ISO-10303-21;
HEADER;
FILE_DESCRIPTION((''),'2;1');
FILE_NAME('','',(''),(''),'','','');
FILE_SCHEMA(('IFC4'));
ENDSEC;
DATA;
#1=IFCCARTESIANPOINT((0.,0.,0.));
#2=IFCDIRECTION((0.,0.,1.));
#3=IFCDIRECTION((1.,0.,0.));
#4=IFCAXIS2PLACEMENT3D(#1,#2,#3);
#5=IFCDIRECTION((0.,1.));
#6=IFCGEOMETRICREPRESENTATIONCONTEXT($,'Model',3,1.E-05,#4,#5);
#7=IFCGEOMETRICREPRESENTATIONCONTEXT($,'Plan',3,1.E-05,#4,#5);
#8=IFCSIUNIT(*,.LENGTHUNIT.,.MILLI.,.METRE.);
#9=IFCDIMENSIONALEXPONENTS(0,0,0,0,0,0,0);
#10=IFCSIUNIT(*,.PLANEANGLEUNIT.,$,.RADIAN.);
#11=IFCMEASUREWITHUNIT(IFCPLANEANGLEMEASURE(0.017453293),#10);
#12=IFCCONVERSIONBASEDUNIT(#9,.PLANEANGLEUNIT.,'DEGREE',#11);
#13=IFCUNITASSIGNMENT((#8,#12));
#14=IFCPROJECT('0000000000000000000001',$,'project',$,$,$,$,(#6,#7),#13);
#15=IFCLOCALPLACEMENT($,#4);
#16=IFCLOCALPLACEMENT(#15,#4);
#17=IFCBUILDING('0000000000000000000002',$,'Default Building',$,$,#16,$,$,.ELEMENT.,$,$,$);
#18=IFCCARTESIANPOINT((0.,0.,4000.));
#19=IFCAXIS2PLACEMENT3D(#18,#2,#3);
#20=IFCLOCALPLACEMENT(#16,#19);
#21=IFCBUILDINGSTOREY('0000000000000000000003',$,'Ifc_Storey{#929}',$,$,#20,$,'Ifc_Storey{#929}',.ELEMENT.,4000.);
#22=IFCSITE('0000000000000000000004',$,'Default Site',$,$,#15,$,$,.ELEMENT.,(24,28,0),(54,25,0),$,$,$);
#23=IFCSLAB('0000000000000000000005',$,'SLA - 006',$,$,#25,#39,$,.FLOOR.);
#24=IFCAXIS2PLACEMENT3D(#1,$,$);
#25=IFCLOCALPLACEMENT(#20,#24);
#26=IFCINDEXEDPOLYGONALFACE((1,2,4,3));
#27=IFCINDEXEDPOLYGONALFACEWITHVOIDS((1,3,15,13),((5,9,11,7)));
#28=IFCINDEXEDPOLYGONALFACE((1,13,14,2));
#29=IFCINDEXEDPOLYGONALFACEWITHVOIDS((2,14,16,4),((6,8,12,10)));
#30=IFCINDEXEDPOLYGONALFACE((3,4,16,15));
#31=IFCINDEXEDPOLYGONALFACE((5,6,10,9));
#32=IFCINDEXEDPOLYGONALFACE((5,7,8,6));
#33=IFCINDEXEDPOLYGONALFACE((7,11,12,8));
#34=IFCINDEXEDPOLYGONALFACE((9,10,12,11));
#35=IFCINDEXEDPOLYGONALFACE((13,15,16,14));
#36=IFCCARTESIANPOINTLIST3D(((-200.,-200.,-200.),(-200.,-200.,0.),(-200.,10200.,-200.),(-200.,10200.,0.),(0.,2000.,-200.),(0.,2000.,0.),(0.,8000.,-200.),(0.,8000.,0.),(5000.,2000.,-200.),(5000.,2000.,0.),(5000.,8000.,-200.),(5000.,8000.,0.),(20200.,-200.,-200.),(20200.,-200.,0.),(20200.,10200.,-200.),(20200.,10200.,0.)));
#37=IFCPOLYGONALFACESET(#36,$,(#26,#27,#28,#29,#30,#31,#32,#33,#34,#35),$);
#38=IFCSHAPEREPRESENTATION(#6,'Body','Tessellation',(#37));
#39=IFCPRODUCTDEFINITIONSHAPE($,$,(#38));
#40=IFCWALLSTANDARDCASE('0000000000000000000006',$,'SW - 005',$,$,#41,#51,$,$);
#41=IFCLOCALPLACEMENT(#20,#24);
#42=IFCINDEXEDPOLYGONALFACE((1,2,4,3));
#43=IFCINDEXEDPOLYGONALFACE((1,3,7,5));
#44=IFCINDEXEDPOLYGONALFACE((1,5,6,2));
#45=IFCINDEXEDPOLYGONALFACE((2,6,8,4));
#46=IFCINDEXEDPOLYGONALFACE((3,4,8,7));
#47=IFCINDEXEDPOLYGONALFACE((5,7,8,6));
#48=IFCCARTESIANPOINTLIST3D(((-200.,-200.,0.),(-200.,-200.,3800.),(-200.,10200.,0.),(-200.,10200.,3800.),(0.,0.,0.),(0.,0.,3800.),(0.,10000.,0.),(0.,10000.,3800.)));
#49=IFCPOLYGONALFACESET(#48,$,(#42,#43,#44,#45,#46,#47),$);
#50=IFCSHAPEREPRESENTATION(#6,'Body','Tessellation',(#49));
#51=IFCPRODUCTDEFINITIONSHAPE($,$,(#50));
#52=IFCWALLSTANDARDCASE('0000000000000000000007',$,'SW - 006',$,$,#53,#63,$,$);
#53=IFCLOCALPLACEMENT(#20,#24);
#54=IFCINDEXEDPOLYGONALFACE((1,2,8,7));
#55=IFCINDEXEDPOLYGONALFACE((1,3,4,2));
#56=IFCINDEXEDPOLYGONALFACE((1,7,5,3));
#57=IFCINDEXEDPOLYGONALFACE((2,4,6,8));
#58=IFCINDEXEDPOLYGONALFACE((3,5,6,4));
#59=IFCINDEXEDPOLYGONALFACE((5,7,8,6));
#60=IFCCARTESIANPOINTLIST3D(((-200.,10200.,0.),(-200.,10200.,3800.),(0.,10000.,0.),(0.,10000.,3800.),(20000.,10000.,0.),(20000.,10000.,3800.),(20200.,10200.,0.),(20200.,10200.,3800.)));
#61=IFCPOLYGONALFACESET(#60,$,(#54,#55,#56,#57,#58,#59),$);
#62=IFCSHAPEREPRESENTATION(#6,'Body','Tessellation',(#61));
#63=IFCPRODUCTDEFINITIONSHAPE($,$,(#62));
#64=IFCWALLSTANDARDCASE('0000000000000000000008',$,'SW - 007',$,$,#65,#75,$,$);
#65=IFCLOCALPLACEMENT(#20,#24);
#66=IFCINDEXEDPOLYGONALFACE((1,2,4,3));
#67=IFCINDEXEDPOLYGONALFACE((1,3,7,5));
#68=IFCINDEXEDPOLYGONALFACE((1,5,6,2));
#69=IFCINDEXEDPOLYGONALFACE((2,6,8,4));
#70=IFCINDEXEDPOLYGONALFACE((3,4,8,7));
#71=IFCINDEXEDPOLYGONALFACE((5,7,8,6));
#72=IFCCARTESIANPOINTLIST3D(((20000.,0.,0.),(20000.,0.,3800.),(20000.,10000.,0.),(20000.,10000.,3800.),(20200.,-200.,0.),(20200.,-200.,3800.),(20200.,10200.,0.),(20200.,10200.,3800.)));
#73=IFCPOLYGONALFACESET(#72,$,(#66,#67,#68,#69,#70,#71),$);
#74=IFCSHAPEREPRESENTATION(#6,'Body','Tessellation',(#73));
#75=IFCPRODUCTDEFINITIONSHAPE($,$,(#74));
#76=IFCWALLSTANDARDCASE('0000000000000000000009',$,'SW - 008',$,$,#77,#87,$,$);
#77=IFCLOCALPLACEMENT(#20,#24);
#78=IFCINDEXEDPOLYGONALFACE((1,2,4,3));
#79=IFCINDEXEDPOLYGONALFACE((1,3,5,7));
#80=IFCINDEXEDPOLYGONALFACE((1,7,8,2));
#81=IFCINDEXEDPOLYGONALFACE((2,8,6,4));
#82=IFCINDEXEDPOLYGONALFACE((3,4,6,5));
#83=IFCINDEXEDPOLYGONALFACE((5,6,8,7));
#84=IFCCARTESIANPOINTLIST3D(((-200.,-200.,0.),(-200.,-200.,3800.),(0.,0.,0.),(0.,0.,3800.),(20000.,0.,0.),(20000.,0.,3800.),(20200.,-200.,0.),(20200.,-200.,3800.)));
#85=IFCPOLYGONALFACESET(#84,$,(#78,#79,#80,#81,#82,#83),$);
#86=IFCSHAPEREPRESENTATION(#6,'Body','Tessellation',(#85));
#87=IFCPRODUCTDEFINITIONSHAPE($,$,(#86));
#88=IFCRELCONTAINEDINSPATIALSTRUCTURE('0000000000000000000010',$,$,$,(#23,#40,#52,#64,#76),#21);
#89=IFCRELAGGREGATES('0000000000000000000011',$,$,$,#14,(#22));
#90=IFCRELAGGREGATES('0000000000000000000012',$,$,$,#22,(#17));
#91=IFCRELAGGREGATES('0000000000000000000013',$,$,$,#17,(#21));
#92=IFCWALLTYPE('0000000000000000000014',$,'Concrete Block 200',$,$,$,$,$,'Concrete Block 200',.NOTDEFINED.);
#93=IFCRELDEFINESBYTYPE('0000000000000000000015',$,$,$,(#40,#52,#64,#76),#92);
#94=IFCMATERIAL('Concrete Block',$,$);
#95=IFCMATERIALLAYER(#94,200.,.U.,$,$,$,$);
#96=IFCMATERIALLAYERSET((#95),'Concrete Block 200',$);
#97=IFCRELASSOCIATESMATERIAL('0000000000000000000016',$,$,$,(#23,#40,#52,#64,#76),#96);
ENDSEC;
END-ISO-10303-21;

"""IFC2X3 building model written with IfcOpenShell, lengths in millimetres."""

from ifc_helpers import new_model, entity, si_unit, converted_unit, direction, frame, origin_with_axes, place, context, project, spatial, polyline, outline, extrude, material, layer, layer_set, layer_usage, type_object, element, save


model = new_model("IFC2X3")

# Units and contexts
model_context = context("Model", 3, precision=1e-05, world=origin_with_axes(), true_north=direction((0.0, 1.0)))
plan_context = context("Plan", 3, precision=1e-05, world=origin_with_axes(), true_north=direction((0.0, 1.0)))
ifc_project = project(units=[si_unit("LENGTHUNIT", "METRE", prefix="MILLI"), converted_unit("PLANEANGLEUNIT", "DEGREE", entity("IfcPlaneAngleMeasure", 0.017453293), si_unit("PLANEANGLEUNIT", "RADIAN"), dimensions=[0, 0, 0, 0, 0, 0, 0])], contexts=[model_context, plan_context])

# Site, building, storey
site_placement = place(None, origin_with_axes())
site = spatial("IfcSite", under=ifc_project, at=site_placement, Name="Default Site", CompositionType="ELEMENT", RefLatitude=(24, 28, 0), RefLongitude=(54, 25, 0))
building_placement = place(site_placement, origin_with_axes())
building = spatial("IfcBuilding", under=site, at=building_placement, Name="Default Building", CompositionType="ELEMENT")
storey_placement = place(building_placement, frame((0.0, 0.0, 4000.0), z_axis=(0.0, 0.0, 1.0), x_axis=(1.0, 0.0, 0.0)))
storey = spatial("IfcBuildingStorey", under=building, at=storey_placement, Name="Ifc_Storey{#929}", LongName="Ifc_Storey{#929}", CompositionType="ELEMENT", Elevation=4000.0)

# Slab, opening
ifc_material = material(Name="Concrete Block")
ifc_layer = layer(ifc_material, 200.0, ventilated="UNKNOWN")
ifc_layer_set = layer_set([ifc_layer], Name="Concrete Block 200")
ifc_layer_usage_1 = layer_usage(ifc_layer_set, "AXIS3", "NEGATIVE", 200.0)
slab_placement = place(storey_placement, frame((-200.0, -200.0, -200.0), z_axis=(0.0, 0.0, 1.0), x_axis=(1.0, 0.0, 0.0)))
slab = element("IfcSlab", 1, at=slab_placement, inside=storey, material=ifc_layer_usage_1, Name="SLA - 006", PredefinedType="FLOOR", context=model_context, shape_type="SweptSolid", body=[
    extrude(outline(polyline([(0.0, 0.0), (20400.0, 0.0), (20400.0, 10400.0), (0.0, 10400.0), (0.0, 0.0)])), origin_with_axes(), (0.0, 0.0, 1.0), 200.0),
])
opening_placement = place(slab_placement, origin_with_axes())
element("IfcOpeningElement", 2, at=opening_placement, cuts=slab, context=model_context, shape_type="SweptSolid", body=[
    extrude(outline(polyline([(5200.0, 2200.0), (200.0, 2200.0), (200.0, 8200.0), (5200.0, 8200.0), (5200.0, 2200.0)])), origin_with_axes(), (0.0, 0.0, 1.0), 200.0),
])

# Walls
ifc_layer_usage_2 = layer_usage(ifc_layer_set, "AXIS2", "POSITIVE", 0.0)
wall_type = type_object("IfcWallType", Name="Concrete Block 200", ElementType="Concrete Block 200", PredefinedType="NOTDEFINED")
wall_1_placement = place(storey_placement, frame((0.0, 0.0, 0.0), z_axis=(0.0, 0.0, 1.0), x_axis=(0.0, 1.0, 0.0)))
element("IfcWallStandardCase", 3, at=wall_1_placement, inside=storey, type_object=wall_type, material=ifc_layer_usage_2, Name="SW - 005", context=model_context, shape_type="SweptSolid", body=[
    extrude(outline(polyline([(0.0, 0.0), (10000.0, 0.0), (10200.0, 200.0), (-200.0, 200.0), (0.0, 0.0)])), origin_with_axes(), (0.0, 0.0, 1.0), 3800.0),
])
ifc_layer_usage_3 = layer_usage(ifc_layer_set, "AXIS2", "POSITIVE", 0.0)
wall_2_placement = place(storey_placement, frame((0.0, 10000.0, 0.0), z_axis=(0.0, 0.0, 1.0), x_axis=(1.0, 0.0, 0.0)))
element("IfcWallStandardCase", 4, at=wall_2_placement, inside=storey, type_object=wall_type, material=ifc_layer_usage_3, Name="SW - 006", context=model_context, shape_type="SweptSolid", body=[
    extrude(outline(polyline([(0.0, 0.0), (20000.0, 0.0), (20200.0, 200.0), (-200.0, 200.0), (0.0, 0.0)])), origin_with_axes(), (0.0, 0.0, 1.0), 3800.0),
])
ifc_layer_usage_4 = layer_usage(ifc_layer_set, "AXIS2", "POSITIVE", 0.0)
wall_3_placement = place(storey_placement, frame((20000.0, 10000.0, 0.0), z_axis=(0.0, 0.0, 1.0), x_axis=(0.0, -1.0, 0.0)))
element("IfcWallStandardCase", 5, at=wall_3_placement, inside=storey, type_object=wall_type, material=ifc_layer_usage_4, Name="SW - 007", context=model_context, shape_type="SweptSolid", body=[
    extrude(outline(polyline([(0.0, 0.0), (10000.0, 0.0), (10200.0, 200.0), (-200.0, 200.0), (0.0, 0.0)])), origin_with_axes(), (0.0, 0.0, 1.0), 3800.0),
])
ifc_layer_usage_5 = layer_usage(ifc_layer_set, "AXIS2", "POSITIVE", 0.0)
wall_4_placement = place(storey_placement, frame((20000.0, 0.0, 0.0), z_axis=(0.0, 0.0, 1.0), x_axis=(-1.0, 0.0, 0.0)))
element("IfcWallStandardCase", 6, at=wall_4_placement, inside=storey, type_object=wall_type, material=ifc_layer_usage_5, Name="SW - 008", context=model_context, shape_type="SweptSolid", body=[
    extrude(outline(polyline([(0.0, 0.0), (20000.0, 0.0), (20200.0, 200.0), (-200.0, 200.0), (0.0, 0.0)])), origin_with_axes(), (0.0, 0.0, 1.0), 3800.0),
])

save(model, "model.ifc")
